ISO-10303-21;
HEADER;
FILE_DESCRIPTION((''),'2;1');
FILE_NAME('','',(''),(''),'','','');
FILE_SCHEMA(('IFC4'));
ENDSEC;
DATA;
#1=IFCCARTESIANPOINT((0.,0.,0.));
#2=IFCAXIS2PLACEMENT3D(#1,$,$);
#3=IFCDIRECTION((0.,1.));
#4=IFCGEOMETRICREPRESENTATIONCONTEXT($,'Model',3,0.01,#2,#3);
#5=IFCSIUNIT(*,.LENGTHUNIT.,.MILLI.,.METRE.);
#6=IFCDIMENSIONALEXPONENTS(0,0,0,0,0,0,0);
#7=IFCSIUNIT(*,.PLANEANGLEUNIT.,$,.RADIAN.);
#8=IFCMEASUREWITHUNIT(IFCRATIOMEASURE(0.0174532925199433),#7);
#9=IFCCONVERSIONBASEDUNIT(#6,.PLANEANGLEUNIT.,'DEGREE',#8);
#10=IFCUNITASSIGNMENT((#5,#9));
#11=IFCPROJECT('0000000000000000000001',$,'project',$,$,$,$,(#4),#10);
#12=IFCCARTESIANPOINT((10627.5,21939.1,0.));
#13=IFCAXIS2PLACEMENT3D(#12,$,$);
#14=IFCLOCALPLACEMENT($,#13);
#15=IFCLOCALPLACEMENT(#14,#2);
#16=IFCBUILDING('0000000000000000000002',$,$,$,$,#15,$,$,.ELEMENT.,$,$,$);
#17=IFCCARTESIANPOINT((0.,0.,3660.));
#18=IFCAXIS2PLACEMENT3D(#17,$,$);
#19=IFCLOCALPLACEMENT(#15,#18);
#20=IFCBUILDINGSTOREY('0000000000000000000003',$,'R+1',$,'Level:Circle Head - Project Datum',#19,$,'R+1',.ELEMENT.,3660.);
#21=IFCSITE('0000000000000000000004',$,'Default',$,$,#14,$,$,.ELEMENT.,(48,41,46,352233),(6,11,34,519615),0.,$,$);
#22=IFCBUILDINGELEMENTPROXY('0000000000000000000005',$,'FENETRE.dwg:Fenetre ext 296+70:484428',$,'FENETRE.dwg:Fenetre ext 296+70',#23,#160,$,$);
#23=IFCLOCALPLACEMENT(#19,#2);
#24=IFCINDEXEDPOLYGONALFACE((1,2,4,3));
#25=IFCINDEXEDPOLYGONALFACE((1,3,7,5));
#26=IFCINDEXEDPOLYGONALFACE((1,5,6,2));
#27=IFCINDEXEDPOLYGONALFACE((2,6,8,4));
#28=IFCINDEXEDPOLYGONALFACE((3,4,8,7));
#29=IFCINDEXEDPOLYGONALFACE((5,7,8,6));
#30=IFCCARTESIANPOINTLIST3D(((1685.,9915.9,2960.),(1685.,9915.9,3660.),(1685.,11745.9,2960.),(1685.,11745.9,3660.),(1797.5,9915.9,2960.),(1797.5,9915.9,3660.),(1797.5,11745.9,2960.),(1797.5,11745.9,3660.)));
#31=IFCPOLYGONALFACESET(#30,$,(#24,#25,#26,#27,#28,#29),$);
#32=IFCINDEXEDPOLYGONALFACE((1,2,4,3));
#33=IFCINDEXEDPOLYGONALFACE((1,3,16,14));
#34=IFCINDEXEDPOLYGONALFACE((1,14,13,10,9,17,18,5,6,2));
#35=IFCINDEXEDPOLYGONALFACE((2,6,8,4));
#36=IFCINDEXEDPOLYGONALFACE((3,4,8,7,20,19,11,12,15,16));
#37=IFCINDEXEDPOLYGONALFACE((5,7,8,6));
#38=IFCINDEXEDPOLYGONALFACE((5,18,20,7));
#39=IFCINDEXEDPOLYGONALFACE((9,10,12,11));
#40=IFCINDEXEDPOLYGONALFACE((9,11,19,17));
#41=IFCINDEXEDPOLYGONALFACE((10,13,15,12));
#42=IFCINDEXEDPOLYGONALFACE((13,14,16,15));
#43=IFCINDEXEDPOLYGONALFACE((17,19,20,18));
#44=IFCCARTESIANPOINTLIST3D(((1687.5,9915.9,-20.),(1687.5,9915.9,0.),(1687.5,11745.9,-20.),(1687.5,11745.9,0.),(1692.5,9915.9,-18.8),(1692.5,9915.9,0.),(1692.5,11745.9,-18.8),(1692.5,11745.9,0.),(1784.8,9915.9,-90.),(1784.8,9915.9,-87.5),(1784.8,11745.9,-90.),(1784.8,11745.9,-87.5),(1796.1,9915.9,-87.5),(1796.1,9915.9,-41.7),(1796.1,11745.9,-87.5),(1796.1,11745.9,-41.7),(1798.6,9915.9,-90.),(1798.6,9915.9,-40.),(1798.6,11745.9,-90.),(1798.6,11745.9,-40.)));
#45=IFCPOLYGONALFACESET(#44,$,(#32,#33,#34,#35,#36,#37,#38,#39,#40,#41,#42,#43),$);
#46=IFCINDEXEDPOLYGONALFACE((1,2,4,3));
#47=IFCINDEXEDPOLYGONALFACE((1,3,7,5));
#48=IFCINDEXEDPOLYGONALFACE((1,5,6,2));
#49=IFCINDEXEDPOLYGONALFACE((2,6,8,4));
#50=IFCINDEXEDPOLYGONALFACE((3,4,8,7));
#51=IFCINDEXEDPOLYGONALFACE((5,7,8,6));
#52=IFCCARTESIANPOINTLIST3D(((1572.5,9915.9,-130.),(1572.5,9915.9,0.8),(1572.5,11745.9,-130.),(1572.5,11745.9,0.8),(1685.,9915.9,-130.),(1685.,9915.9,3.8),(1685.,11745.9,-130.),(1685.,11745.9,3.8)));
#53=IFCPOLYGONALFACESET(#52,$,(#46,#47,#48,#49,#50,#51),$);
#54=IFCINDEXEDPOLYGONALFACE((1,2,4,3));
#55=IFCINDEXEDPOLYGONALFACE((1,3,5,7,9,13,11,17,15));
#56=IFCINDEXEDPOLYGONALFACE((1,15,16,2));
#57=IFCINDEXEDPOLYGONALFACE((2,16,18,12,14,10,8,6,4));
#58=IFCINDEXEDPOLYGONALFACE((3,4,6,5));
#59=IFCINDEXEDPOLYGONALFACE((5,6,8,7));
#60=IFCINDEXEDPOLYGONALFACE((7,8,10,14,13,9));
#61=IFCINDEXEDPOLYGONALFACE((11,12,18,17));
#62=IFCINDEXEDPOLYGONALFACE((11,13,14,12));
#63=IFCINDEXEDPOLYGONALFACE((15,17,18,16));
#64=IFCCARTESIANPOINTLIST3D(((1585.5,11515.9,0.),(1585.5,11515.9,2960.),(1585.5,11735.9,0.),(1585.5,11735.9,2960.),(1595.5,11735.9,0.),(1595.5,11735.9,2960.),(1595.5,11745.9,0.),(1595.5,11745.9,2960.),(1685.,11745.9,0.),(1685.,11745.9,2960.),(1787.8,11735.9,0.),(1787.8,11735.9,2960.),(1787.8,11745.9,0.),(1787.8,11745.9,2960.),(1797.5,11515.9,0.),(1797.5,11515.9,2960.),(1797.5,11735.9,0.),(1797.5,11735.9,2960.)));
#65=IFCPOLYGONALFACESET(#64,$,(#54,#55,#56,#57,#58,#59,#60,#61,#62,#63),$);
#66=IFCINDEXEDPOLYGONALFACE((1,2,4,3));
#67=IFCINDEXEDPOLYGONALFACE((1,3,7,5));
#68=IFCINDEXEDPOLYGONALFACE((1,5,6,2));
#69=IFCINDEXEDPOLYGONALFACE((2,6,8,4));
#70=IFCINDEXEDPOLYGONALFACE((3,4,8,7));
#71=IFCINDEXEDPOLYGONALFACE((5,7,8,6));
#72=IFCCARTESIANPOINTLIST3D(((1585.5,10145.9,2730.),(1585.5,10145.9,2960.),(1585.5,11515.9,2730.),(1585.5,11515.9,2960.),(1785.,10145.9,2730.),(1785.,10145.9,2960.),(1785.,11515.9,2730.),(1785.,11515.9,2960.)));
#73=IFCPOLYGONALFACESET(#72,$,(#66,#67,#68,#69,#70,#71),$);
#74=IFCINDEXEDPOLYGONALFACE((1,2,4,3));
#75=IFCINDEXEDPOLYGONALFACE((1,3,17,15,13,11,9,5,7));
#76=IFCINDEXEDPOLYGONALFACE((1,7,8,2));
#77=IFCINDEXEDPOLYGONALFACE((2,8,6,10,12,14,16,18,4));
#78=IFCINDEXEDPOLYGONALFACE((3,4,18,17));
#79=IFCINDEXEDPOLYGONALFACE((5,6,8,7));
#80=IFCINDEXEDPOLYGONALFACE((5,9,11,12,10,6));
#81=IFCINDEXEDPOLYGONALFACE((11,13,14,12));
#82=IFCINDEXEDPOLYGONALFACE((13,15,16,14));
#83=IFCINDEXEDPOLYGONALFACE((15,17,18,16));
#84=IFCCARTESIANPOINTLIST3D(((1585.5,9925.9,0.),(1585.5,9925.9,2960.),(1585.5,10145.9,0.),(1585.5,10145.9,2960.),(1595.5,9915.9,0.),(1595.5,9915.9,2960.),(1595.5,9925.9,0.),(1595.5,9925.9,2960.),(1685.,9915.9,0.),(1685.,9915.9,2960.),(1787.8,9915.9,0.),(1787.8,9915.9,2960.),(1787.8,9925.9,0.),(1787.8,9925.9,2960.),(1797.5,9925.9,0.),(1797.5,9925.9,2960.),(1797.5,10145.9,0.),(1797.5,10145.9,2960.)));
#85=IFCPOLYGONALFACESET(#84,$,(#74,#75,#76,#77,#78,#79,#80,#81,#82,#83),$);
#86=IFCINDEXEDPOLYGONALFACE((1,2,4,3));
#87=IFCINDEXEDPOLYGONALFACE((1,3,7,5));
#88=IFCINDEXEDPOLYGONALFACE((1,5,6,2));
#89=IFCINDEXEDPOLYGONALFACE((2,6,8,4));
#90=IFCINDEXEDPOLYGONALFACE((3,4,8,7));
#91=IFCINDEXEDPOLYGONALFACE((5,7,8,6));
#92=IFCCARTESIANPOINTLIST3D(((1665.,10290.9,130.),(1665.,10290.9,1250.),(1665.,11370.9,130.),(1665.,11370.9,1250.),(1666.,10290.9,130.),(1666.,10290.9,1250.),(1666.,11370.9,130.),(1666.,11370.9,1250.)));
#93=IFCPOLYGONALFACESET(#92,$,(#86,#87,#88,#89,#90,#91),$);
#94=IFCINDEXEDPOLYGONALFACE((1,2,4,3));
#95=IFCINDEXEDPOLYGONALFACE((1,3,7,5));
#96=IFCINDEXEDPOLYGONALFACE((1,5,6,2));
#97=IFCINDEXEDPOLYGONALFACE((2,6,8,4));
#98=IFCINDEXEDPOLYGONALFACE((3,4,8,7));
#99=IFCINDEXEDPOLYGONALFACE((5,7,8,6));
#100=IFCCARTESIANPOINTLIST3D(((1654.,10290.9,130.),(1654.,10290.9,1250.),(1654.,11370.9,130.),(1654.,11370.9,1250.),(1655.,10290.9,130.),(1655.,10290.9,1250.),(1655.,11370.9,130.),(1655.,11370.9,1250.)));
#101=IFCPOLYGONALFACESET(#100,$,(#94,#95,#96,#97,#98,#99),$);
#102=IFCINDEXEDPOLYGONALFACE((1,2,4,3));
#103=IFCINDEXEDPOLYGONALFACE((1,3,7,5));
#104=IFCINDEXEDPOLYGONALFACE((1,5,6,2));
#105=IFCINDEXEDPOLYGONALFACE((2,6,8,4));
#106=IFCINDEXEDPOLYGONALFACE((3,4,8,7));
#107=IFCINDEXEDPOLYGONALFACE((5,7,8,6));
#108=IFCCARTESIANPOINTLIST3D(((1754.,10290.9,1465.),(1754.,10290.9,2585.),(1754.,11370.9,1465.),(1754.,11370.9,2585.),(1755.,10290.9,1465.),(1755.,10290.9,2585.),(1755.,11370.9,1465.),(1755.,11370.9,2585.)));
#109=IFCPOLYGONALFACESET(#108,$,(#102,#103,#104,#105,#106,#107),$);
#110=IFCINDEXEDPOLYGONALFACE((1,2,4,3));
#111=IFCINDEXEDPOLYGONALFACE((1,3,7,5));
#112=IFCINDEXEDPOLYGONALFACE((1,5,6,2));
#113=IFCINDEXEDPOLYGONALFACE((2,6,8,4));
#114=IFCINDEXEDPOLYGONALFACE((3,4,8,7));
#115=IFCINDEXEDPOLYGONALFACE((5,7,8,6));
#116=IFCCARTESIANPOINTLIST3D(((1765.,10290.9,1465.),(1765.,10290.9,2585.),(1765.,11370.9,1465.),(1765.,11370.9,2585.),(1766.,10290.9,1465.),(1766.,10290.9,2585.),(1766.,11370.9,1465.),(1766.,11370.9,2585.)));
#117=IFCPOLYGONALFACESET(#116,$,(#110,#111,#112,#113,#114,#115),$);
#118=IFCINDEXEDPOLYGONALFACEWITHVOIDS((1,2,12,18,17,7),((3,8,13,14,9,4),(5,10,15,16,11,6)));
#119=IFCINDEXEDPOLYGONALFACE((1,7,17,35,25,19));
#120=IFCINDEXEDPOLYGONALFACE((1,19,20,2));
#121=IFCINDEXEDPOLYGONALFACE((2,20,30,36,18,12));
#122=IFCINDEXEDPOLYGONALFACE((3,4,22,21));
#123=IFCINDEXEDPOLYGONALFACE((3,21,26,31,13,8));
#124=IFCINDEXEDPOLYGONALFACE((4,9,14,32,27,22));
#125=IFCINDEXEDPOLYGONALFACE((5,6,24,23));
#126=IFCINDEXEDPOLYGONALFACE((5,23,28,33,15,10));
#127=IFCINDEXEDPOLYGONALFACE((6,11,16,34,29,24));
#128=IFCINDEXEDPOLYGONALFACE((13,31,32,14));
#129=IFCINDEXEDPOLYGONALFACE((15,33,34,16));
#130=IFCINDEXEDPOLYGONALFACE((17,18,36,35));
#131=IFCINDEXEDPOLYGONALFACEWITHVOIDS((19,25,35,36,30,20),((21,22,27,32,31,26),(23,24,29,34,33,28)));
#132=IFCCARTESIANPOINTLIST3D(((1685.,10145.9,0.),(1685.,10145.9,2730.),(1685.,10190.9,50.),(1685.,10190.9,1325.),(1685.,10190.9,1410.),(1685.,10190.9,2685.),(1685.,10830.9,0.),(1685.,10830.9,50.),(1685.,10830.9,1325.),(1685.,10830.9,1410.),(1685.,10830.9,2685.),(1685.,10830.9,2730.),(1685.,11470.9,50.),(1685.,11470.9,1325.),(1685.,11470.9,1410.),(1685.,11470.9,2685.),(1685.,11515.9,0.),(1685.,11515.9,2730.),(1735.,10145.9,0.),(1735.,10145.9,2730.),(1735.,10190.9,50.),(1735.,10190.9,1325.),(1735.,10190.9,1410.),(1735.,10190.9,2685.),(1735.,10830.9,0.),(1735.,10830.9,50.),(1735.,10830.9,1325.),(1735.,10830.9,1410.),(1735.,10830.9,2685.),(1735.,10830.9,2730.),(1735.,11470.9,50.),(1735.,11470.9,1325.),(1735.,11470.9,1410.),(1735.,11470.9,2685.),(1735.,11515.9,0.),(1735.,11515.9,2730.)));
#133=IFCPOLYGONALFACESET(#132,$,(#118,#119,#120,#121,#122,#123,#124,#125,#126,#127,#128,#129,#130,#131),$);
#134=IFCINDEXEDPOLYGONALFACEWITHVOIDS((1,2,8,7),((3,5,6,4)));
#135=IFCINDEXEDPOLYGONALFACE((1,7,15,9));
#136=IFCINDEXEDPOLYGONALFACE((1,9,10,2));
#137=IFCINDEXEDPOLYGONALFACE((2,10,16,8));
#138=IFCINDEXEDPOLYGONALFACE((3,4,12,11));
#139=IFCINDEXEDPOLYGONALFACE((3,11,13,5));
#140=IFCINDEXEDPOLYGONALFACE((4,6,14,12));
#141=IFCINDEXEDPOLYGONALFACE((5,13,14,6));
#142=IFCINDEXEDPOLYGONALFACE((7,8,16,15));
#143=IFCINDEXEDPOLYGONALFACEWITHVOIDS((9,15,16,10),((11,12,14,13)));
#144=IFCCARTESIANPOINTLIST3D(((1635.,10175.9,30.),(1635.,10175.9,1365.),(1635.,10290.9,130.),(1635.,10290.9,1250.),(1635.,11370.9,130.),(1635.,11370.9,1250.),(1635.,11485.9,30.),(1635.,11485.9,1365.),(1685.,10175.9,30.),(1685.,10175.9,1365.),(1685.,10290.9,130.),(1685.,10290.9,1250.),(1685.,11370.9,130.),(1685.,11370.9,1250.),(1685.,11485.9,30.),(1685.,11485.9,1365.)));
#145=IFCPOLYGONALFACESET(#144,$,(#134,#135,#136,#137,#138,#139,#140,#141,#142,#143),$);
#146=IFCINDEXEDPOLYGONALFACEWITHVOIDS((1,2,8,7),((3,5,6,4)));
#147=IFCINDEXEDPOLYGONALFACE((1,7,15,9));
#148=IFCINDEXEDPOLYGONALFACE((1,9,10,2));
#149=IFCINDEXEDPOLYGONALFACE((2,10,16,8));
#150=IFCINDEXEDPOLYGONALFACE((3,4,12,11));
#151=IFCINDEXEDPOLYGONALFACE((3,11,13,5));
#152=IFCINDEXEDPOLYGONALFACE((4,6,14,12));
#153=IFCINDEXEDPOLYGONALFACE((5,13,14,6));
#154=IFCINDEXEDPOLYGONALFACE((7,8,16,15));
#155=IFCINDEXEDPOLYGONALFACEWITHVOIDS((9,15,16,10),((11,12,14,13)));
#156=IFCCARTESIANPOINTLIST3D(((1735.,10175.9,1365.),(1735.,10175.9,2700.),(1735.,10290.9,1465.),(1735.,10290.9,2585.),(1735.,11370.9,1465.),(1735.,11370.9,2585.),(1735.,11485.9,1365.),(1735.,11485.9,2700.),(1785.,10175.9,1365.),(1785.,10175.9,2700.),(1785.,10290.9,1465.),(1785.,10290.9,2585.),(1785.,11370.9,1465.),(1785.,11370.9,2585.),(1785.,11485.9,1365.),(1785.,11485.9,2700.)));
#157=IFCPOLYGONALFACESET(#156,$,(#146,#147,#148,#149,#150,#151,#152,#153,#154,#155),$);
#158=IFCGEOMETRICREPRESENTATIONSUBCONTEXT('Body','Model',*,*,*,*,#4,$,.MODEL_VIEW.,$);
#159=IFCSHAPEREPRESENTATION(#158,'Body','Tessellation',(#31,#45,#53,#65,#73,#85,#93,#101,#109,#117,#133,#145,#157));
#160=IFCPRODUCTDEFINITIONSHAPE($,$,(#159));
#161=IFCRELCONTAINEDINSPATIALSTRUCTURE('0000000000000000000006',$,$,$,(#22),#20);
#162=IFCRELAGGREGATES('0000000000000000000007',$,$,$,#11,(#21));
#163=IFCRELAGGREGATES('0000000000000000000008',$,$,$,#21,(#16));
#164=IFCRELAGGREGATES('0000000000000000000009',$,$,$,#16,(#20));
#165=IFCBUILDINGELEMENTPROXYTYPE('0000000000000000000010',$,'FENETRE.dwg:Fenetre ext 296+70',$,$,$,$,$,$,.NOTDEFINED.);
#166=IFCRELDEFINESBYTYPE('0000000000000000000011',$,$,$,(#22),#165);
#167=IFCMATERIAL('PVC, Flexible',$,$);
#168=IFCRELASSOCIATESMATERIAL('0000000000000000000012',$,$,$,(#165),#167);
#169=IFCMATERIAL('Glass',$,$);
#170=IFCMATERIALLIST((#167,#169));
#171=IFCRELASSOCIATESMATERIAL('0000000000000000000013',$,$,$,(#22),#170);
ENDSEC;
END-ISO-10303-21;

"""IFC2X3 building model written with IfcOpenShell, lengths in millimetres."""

from ifc_helpers import new_model, entity, si_unit, converted_unit, direction, frame, frame_2d, origin, origin_2d_with_axis, place, context, subcontext, project, spatial, polyline, rectangle, outline, extrude, source, transform, mapped, material, material_list, type_object, type_shapes, element, save


model = new_model("IFC2X3")

# Units and contexts
model_context = context("Model", 3, precision=0.01, world=origin(), true_north=direction((0.0, 1.0)))
body_context = subcontext(model_context, "Body", "Model", "MODEL_VIEW")
ifc_project = project(units=[si_unit("LENGTHUNIT", "METRE", prefix="MILLI"), converted_unit("PLANEANGLEUNIT", "DEGREE", entity("IfcRatioMeasure", 0.0174532925199433), si_unit("PLANEANGLEUNIT", "RADIAN"), dimensions=[0, 0, 0, 0, 0, 0, 0])], contexts=[model_context])

# Site, building, storey
site_placement = place(None, frame((10627.5, 21939.1, 0.0)))
site = spatial("IfcSite", under=ifc_project, at=site_placement, Name="Default", CompositionType="ELEMENT", RefLatitude=(48, 41, 46, 352233), RefLongitude=(6, 11, 34, 519615), RefElevation=0.0)
building_placement = place(site_placement, origin())
building = spatial("IfcBuilding", under=site, at=building_placement, CompositionType="ELEMENT")
storey_placement = place(building_placement, frame((0.0, 0.0, 3660.0)))
storey = spatial("IfcBuildingStorey", under=building, at=storey_placement, Name="R+1", ObjectType="Level:Circle Head - Project Datum", LongName="R+1", CompositionType="ELEMENT", Elevation=3660.0)

# Building element proxy
ifc_material_1 = material(Name="PVC, Flexible")
ifc_material_2 = material(Name="Glass")
building_element_proxy_type_1 = type_object("IfcBuildingElementProxyType", Name="FENETRE.dwg:Fenetre ext 296+70", PredefinedType="NOTDEFINED", material=ifc_material_1)
shared_shape_1 = source(origin(), body_context, "Body", "SweptSolid", [
    extrude(rectangle(XDim=112.5, YDim=1830.0, at=origin_2d_with_axis()), frame((-10.4, -56.3, 2960.0), z_axis=(0.0, 0.0, 1.0), x_axis=(0.0, 1.0, 0.0)), (0.0, 0.0, 1.0), 700.0),
    extrude(outline(polyline([(27.5, -64.4), (47.5, -64.4), (47.5, -59.4), (28.8, -59.4), (7.5, 46.7), (-42.5, 46.7), (-42.5, 32.9), (-40.0, 32.9), (-40.0, 44.2), (5.8, 44.2), (27.5, -64.4)])), frame((-925.4, -66.9, -47.5), z_axis=(1.0, 0.0, 0.0), x_axis=(0.0, 0.0, 1.0)), (0.0, 0.0, 1.0), 1830.0),
    extrude(outline(polyline([(-54.5, -66.1), (58.0, -66.1), (54.5, 67.6), (-58.0, 64.6), (-54.5, -66.1)])), frame((-925.4, 56.3, -63.8), z_axis=(1.0, 0.0, 0.0), x_axis=(0.0, -0.999645, 0.02665)), (0.0, 0.0, 1.0), 1830.0),
    extrude(outline(polyline([(-97.0, -55.6), (5.9, -55.6), (95.4, -55.6), (95.4, -45.6), (105.4, -45.6), (105.4, 174.4), (-106.6, 174.4), (-106.6, -45.6), (-97.0, -45.6), (-97.0, -55.6)])), frame((849.0, -5.9, 0.0), z_axis=(0.0, 0.0, 1.0), x_axis=(0.0, 1.0, 0.0)), (0.0, 0.0, 1.0), 2960.0),
    extrude(rectangle(XDim=1370.0, YDim=199.5, at=origin_2d_with_axis()), frame((-10.4, -0.3, 2730.0), z_axis=(0.0, 0.0, 1.0), x_axis=(-1.0, 0.0, 0.0)), (0.0, 0.0, 1.0), 230.0),
    extrude(outline(polyline([(-55.6, 97.0), (-55.6, -5.9), (-55.6, -95.4), (-45.6, -95.4), (-45.6, -105.4), (174.4, -105.4), (174.4, 106.6), (-45.6, 106.6), (-45.6, 97.0), (-55.6, 97.0)])), frame((-869.9, -5.9, 0.0), z_axis=(0.0, 0.0, -1.0), x_axis=(1.0, 0.0, 0.0)), (0.0, 0.0, -1.0), 2960.0),
    extrude(rectangle(XDim=1080.0, YDim=1.0, at=origin_2d_with_axis()), frame((-10.4, 19.5, 130.0), z_axis=(0.0, 0.0, 1.0), x_axis=(-1.0, 0.0, 0.0)), (0.0, 0.0, 1.0), 1120.0),
    extrude(rectangle(XDim=1080.0, YDim=1.0, at=origin_2d_with_axis()), frame((-10.4, 30.5, 130.0), z_axis=(0.0, 0.0, 1.0), x_axis=(-1.0, 0.0, 0.0)), (0.0, 0.0, 1.0), 1120.0),
    extrude(rectangle(XDim=1080.0, YDim=1.0, at=frame_2d((0.0, 0.0), x_axis=(1.0, 0.0))), frame((-10.4, -69.5, 1465.0), z_axis=(0.0, 0.0, 1.0), x_axis=(-1.0, 0.0, 0.0)), (0.0, 0.0, 1.0), 1120.0),
    extrude(rectangle(XDim=1080.0, YDim=1.0, at=frame_2d((0.0, 0.0), x_axis=(1.0, 0.0))), frame((-10.4, -80.5, 1465.0), z_axis=(0.0, 0.0, 1.0), x_axis=(-1.0, 0.0, 0.0)), (0.0, 0.0, 1.0), 1120.0),
    extrude(outline(polyline([(-685.0, -1365.0), (0.0, -1365.0), (685.0, -1365.0), (685.0, 1365.0), (0.0, 1365.0), (-685.0, 1365.0), (-685.0, -1365.0)]), holes=[polyline([(-640.0, -1320.0), (-640.0, -45.0), (0.0, -45.0), (640.0, -45.0), (640.0, -1320.0), (0.0, -1320.0), (-640.0, -1320.0)]), polyline([(-640.0, 40.0), (-640.0, 1315.0), (0.0, 1315.0), (640.0, 1315.0), (640.0, 40.0), (0.0, 40.0), (-640.0, 40.0)])]), frame((-10.4, -50.0, 1365.0), z_axis=(0.0, 1.0, 0.0), x_axis=(1.0, 0.0, 0.0)), (0.0, 0.0, 1.0), 50.0),
    extrude(outline(polyline([(-655.0, -667.5), (655.0, -667.5), (655.0, 667.5), (-655.0, 667.5), (-655.0, -667.5)]), holes=[polyline([(-540.0, 552.5), (540.0, 552.5), (540.0, -567.5), (-540.0, -567.5), (-540.0, 552.5)])]), frame((-10.4, 0.0, 697.5), z_axis=(0.0, 1.0, 0.0), x_axis=(-1.0, 0.0, 0.0)), (0.0, 0.0, 1.0), 50.0),
    extrude(outline(polyline([(-655.0, -667.5), (655.0, -667.5), (655.0, 667.5), (-655.0, 667.5), (-655.0, -667.5)]), holes=[polyline([(-540.0, 552.5), (540.0, 552.5), (540.0, -567.5), (-540.0, -567.5), (-540.0, 552.5)])]), frame((-10.4, -100.0, 2032.5), z_axis=(0.0, 1.0, 0.0), x_axis=(-1.0, 0.0, 0.0)), (0.0, 0.0, 1.0), 50.0),
])
type_shapes(building_element_proxy_type_1, [shared_shape_1])
ifc_material_list_1 = material_list([ifc_material_1, ifc_material_2])
proxy_1_placement = place(storey_placement, frame((1685.0, 10841.3, 0.0), z_axis=(0.0, 0.0, 1.0), x_axis=(0.0, 1.0, 0.0)))
element("IfcBuildingElementProxy", 1, at=proxy_1_placement, inside=storey, type_object=building_element_proxy_type_1, material=ifc_material_list_1, Name="FENETRE.dwg:Fenetre ext 296+70:484428", ObjectType="FENETRE.dwg:Fenetre ext 296+70", context=body_context, shape_type="MappedRepresentation", body=[
    mapped(shared_shape_1, transform((0.0, 0.0, 0.0), scale=1.0)),
])

save(model, "model.ifc")
